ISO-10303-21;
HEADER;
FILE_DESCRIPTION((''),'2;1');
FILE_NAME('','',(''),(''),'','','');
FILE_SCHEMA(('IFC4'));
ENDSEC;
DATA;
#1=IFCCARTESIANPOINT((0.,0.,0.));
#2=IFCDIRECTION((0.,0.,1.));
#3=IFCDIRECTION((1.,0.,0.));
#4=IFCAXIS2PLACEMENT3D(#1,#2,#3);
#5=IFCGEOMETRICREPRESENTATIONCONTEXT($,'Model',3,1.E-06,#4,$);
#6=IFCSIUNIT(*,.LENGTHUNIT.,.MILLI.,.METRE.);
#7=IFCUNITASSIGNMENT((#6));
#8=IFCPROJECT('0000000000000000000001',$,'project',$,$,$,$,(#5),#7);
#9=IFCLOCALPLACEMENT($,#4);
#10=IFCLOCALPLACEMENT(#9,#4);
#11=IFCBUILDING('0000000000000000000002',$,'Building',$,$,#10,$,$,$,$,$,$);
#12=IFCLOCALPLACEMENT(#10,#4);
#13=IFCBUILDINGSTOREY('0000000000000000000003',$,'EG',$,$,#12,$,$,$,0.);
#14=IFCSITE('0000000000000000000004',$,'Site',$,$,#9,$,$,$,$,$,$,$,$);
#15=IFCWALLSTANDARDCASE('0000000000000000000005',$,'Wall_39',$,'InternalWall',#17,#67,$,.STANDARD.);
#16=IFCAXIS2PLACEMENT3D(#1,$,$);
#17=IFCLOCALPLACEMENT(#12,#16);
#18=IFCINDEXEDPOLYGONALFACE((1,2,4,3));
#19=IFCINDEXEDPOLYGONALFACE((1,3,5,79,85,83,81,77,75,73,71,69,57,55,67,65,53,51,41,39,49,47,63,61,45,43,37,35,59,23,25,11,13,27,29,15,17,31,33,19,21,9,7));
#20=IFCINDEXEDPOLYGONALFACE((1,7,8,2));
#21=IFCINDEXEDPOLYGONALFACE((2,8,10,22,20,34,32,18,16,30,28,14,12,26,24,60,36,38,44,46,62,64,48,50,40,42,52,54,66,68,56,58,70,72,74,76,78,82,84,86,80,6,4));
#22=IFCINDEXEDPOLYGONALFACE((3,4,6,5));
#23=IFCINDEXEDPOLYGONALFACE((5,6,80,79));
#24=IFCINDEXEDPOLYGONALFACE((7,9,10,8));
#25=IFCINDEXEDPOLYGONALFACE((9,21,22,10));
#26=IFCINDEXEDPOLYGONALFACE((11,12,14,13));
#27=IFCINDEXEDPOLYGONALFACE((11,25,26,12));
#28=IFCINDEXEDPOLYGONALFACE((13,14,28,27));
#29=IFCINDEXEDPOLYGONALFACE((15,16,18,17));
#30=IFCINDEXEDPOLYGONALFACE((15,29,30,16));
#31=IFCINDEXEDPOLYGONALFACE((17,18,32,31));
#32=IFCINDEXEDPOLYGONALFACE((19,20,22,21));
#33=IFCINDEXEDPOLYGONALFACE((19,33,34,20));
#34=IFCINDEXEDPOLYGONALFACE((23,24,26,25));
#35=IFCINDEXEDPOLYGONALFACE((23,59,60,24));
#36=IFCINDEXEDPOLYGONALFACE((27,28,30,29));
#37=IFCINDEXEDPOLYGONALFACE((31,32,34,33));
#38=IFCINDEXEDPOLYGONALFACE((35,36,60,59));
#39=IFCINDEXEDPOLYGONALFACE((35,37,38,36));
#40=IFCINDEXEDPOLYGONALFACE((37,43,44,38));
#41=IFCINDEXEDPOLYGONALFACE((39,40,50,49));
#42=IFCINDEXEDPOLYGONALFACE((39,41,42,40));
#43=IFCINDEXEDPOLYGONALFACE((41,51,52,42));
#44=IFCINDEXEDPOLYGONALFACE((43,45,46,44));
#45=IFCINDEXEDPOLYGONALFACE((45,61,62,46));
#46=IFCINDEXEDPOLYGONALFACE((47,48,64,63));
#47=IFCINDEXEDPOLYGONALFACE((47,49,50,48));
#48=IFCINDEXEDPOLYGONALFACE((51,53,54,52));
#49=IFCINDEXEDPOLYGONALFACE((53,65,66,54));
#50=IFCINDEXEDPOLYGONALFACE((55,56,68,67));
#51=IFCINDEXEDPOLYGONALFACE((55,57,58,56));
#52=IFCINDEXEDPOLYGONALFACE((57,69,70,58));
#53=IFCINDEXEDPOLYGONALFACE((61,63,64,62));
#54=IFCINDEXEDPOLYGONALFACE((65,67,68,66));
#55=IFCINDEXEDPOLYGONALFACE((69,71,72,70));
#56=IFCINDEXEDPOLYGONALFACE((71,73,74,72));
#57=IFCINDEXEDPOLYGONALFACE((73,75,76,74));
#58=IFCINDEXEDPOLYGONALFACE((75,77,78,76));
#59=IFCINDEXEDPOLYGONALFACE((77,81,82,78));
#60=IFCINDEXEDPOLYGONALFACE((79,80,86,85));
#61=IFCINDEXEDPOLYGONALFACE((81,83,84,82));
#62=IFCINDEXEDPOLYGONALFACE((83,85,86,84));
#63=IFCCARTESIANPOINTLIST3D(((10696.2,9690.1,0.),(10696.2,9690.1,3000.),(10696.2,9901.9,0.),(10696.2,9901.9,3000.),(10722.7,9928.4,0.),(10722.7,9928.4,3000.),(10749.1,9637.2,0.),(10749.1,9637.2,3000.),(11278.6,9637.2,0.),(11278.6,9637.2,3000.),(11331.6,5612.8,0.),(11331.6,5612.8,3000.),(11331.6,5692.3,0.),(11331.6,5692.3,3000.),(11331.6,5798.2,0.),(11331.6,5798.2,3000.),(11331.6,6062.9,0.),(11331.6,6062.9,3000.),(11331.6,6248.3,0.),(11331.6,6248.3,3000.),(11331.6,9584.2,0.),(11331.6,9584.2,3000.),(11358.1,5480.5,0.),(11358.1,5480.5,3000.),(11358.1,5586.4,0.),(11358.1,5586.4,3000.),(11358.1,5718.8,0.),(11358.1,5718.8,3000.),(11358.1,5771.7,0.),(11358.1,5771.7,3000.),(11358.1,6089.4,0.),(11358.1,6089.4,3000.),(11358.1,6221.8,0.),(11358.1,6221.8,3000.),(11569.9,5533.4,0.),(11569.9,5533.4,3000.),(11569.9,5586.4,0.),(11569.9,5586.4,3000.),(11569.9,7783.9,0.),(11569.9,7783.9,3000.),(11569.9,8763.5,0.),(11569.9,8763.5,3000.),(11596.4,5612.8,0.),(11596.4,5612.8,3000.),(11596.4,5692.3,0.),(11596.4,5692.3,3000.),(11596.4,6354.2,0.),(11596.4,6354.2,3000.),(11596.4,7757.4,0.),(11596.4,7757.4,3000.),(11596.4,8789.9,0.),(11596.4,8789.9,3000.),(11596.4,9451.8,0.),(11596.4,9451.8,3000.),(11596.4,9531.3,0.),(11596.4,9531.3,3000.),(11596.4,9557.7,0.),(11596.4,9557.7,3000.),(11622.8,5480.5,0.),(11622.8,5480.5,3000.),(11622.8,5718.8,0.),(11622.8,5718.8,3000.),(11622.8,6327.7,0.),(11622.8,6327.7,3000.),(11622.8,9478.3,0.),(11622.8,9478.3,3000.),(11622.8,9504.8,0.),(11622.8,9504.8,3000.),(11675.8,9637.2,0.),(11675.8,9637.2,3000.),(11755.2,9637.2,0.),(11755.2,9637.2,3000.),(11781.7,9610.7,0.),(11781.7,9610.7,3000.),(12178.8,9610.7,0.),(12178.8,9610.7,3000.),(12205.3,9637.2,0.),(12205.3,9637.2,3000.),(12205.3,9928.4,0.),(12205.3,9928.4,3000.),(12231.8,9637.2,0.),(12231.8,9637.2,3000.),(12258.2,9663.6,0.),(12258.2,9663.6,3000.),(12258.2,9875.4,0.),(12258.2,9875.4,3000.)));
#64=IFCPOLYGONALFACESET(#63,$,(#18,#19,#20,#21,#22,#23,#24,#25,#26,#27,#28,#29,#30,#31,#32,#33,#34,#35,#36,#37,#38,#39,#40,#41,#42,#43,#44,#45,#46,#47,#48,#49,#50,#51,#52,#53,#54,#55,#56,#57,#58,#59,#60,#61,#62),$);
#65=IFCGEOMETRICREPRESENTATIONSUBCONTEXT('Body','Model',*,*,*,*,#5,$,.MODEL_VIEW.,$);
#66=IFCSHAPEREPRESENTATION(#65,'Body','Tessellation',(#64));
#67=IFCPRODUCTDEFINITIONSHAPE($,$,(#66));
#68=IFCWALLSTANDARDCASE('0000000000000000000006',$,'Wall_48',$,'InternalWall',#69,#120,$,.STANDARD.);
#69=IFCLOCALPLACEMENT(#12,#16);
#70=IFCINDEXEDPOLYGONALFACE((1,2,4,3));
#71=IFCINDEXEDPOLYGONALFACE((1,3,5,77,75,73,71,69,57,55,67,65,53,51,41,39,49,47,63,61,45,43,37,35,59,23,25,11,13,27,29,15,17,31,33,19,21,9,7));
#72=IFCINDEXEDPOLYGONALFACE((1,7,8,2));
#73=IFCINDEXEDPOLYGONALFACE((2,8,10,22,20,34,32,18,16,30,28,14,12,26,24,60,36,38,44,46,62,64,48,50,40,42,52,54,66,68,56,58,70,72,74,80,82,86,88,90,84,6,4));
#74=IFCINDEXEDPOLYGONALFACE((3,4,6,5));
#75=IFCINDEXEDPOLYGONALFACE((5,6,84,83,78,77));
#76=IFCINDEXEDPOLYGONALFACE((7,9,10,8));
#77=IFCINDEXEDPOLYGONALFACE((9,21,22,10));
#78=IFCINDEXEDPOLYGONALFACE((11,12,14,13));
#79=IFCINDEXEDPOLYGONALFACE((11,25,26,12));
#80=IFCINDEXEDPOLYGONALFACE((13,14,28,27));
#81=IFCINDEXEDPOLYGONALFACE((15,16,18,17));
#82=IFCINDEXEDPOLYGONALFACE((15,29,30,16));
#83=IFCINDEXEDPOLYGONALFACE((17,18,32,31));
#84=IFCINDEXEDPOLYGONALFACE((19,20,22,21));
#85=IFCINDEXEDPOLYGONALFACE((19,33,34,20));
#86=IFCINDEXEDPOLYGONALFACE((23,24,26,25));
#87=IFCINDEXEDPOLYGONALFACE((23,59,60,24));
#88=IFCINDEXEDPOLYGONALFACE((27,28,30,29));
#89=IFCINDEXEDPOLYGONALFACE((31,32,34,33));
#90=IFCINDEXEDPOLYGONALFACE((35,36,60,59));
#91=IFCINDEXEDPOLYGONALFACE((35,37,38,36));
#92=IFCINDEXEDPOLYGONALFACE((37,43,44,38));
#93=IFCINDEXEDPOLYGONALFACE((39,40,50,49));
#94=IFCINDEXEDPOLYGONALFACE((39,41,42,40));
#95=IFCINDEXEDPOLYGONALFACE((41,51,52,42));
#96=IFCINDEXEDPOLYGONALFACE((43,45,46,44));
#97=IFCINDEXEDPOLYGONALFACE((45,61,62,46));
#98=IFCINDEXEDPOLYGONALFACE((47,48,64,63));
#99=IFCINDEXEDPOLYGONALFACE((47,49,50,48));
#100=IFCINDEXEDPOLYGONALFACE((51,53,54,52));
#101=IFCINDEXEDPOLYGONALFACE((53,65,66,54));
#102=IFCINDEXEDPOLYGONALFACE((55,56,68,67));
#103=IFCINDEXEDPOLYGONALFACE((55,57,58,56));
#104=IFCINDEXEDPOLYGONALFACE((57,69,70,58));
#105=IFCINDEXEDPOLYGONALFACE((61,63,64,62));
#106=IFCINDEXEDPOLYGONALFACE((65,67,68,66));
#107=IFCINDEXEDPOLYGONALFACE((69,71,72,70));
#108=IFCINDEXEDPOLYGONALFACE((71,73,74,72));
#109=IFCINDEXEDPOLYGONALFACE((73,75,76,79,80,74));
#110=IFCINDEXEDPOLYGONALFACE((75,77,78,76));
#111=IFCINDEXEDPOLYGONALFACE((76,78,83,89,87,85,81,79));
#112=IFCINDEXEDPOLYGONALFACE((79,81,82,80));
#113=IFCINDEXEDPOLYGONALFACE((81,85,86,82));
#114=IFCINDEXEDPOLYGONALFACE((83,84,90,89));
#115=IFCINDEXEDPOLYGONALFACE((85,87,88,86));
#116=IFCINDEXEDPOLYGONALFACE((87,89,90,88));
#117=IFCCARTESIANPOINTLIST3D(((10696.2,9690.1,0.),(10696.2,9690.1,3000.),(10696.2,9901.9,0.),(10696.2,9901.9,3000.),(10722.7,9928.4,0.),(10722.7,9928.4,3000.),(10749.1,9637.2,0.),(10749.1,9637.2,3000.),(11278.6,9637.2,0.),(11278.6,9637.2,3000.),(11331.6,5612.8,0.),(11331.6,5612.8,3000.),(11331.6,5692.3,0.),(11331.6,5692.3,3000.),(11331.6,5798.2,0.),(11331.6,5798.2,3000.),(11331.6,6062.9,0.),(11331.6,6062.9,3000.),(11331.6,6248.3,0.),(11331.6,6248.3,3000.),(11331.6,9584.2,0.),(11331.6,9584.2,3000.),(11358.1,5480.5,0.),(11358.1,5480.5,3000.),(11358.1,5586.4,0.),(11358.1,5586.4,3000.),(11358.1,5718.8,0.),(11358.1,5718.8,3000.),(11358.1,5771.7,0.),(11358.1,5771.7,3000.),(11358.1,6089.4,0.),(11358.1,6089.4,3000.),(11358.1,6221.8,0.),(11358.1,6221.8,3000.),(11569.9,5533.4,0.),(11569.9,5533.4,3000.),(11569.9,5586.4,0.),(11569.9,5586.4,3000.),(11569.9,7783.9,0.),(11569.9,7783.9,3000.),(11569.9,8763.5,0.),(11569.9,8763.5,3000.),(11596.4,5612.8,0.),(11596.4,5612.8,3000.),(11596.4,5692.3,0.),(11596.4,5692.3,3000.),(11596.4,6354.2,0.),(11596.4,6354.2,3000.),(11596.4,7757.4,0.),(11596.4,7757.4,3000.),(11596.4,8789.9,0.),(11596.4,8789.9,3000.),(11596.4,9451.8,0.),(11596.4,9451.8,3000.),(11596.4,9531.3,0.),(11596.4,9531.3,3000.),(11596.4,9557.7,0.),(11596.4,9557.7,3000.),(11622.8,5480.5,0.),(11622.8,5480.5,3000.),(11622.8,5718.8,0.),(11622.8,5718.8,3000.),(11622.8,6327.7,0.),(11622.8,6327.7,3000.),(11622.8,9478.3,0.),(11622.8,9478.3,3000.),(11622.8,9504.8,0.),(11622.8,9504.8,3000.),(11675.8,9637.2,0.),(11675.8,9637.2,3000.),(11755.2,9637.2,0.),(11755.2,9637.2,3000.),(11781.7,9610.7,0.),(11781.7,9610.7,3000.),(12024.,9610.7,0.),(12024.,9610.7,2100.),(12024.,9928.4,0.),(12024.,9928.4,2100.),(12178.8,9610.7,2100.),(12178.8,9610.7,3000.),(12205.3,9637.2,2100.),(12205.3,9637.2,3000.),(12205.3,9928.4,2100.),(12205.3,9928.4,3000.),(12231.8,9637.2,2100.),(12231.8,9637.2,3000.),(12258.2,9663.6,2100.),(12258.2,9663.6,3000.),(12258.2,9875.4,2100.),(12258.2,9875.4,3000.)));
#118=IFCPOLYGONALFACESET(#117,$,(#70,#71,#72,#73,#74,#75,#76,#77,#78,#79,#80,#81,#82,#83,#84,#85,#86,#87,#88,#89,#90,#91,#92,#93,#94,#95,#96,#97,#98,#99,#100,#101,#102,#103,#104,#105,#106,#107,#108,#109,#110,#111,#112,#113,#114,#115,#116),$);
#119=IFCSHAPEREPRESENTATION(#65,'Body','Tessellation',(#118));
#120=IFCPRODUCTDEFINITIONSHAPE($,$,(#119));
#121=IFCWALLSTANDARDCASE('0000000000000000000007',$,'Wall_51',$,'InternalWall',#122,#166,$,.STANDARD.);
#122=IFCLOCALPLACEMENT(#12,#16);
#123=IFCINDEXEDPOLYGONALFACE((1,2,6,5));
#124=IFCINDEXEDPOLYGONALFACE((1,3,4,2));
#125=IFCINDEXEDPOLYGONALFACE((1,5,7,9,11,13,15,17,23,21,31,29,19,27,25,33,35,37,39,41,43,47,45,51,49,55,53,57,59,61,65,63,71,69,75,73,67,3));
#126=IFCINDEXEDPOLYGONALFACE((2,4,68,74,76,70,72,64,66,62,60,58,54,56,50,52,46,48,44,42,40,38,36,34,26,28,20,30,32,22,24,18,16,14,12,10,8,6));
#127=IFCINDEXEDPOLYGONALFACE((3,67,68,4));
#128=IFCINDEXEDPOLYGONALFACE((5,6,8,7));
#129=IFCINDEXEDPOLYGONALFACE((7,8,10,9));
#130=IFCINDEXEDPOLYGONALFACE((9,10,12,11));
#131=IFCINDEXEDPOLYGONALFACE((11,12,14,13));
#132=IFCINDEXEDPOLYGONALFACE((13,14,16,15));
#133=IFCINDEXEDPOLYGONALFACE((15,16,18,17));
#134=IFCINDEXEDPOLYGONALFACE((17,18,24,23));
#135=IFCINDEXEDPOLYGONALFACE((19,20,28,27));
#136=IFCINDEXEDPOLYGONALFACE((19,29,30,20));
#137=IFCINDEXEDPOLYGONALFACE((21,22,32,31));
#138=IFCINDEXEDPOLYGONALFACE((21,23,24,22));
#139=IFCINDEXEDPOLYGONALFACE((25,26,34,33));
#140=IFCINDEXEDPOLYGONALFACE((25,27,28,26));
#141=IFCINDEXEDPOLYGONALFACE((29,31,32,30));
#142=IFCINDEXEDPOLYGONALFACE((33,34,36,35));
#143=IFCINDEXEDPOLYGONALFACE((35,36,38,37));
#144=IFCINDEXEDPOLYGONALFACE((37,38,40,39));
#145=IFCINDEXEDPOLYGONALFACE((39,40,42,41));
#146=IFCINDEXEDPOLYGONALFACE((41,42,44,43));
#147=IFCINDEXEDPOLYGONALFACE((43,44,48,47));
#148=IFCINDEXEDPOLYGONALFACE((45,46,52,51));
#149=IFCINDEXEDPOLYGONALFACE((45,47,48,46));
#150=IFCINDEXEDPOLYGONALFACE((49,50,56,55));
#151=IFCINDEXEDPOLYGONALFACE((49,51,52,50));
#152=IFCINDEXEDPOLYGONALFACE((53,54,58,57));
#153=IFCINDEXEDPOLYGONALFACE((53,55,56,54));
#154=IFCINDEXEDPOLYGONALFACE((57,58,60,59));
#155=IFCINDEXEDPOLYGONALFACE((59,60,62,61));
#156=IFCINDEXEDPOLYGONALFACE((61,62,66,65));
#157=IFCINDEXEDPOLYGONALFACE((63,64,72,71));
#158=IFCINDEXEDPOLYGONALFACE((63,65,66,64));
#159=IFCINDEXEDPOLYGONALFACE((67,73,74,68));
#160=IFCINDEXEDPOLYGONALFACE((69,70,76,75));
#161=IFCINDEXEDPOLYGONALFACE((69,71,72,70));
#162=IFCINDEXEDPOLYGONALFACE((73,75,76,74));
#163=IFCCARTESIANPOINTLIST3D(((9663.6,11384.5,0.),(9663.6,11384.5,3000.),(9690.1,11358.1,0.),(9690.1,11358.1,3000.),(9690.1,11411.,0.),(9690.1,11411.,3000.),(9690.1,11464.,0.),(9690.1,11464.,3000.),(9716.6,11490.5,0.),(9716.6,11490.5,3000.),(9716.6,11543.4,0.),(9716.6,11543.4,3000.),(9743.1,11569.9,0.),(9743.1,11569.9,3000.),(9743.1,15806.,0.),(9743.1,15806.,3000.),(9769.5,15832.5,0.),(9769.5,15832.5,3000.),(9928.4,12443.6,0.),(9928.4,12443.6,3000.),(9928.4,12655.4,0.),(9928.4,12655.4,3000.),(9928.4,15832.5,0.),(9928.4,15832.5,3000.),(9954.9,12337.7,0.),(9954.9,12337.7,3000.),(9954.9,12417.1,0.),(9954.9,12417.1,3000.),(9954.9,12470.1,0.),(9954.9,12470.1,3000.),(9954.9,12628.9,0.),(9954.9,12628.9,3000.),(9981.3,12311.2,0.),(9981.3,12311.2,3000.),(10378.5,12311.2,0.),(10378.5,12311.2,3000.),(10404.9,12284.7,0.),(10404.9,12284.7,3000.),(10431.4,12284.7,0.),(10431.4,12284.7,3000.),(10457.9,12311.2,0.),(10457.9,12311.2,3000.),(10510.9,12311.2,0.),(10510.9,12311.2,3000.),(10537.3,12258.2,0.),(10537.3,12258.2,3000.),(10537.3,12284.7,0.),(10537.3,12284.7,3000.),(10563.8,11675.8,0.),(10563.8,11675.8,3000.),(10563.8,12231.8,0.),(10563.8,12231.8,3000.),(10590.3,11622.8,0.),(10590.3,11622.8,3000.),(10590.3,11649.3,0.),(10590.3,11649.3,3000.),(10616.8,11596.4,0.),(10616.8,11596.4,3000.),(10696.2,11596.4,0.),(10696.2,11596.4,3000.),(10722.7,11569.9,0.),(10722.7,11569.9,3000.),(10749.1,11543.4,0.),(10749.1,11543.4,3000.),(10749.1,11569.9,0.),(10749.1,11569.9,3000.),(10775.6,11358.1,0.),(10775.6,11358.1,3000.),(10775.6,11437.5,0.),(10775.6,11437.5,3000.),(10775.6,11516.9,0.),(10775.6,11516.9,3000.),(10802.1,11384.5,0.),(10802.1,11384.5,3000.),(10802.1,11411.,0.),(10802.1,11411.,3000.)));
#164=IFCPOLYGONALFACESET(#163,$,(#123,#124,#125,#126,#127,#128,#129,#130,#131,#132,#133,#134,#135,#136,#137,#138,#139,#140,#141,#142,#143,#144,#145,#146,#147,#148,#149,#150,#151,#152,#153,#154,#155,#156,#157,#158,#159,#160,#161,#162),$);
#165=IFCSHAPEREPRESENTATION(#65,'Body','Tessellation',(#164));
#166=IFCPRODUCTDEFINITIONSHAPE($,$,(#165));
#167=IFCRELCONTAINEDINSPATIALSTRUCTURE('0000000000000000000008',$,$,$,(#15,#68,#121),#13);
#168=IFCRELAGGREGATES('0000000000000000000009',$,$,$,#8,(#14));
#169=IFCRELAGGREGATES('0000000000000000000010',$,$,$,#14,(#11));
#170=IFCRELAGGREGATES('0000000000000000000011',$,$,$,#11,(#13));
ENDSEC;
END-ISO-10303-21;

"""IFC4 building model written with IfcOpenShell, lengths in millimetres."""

from ifc_helpers import new_model, si_unit, frame, origin_with_axes, place, context, subcontext, project, spatial, polyline, rectangle, outline, extrude, element, save


model = new_model("IFC4")

# Units and contexts
model_context = context("Model", 3, precision=1e-06, world=origin_with_axes())
body_context = subcontext(model_context, "Body", "Model", "MODEL_VIEW")
ifc_project = project(units=[si_unit("LENGTHUNIT", "METRE", prefix="MILLI")], contexts=[model_context])

# Site, building, storey
site_placement = place(None, origin_with_axes())
site = spatial("IfcSite", under=ifc_project, at=site_placement, Name="Site")
building_placement = place(site_placement, origin_with_axes())
building = spatial("IfcBuilding", under=site, at=building_placement, Name="Building")
storey_placement = place(building_placement, origin_with_axes())
storey = spatial("IfcBuildingStorey", under=building, at=storey_placement, Name="EG", Elevation=0.0)

# Wall
wall_1_placement = place(storey_placement, origin_with_axes())
element("IfcWallStandardCase", 1, at=wall_1_placement, inside=storey, Name="Wall_39", ObjectType="InternalWall", PredefinedType="STANDARD", context=body_context, shape_type="SweptSolid", body=[
    extrude(outline(polyline([(11358.1, 5480.5, 0.0), (11358.1, 5586.4, 0.0), (11331.6, 5612.8, 0.0), (11331.6, 5692.3, 0.0), (11358.1, 5718.8, 0.0), (11358.1, 5771.7, 0.0), (11331.6, 5798.2, 0.0), (11331.6, 6062.9, 0.0), (11358.1, 6089.4, 0.0), (11358.1, 6221.8, 0.0), (11331.6, 6248.3, 0.0), (11331.6, 9584.2, 0.0), (11278.6, 9637.2, 0.0), (10749.1, 9637.2, 0.0), (10696.2, 9690.1, 0.0), (10696.2, 9901.9, 0.0), (10722.7, 9928.4, 0.0), (12205.3, 9928.4, 0.0), (12258.2, 9875.4, 0.0), (12258.2, 9663.6, 0.0), (12231.8, 9637.2, 0.0), (12205.3, 9637.2, 0.0), (12178.8, 9610.7, 0.0), (11781.7, 9610.7, 0.0), (11755.2, 9637.2, 0.0), (11675.8, 9637.2, 0.0), (11596.4, 9557.7, 0.0), (11596.4, 9531.3, 0.0), (11622.8, 9504.8, 0.0), (11622.8, 9478.3, 0.0), (11596.4, 9451.8, 0.0), (11596.4, 8789.9, 0.0), (11569.9, 8763.5, 0.0), (11569.9, 7783.9, 0.0), (11596.4, 7757.4, 0.0), (11596.4, 6354.2, 0.0), (11622.8, 6327.7, 0.0), (11622.8, 5718.8, 0.0), (11596.4, 5692.3, 0.0), (11596.4, 5612.8, 0.0), (11569.9, 5586.4, 0.0), (11569.9, 5533.4, 0.0), (11622.8, 5480.5, 0.0), (11358.1, 5480.5, 0.0)])), origin_with_axes(), (0.0, 0.0, 1.0), 3000.0),
])

# Wall, opening
wall_2_placement = place(storey_placement, origin_with_axes())
wall_2 = element("IfcWallStandardCase", 2, at=wall_2_placement, inside=storey, Name="Wall_48", ObjectType="InternalWall", PredefinedType="STANDARD", context=body_context, shape_type="SweptSolid", body=[
    extrude(outline(polyline([(11358.1, 5480.5, 0.0), (11358.1, 5586.4, 0.0), (11331.6, 5612.8, 0.0), (11331.6, 5692.3, 0.0), (11358.1, 5718.8, 0.0), (11358.1, 5771.7, 0.0), (11331.6, 5798.2, 0.0), (11331.6, 6062.9, 0.0), (11358.1, 6089.4, 0.0), (11358.1, 6221.8, 0.0), (11331.6, 6248.3, 0.0), (11331.6, 9584.2, 0.0), (11278.6, 9637.2, 0.0), (10749.1, 9637.2, 0.0), (10696.2, 9690.1, 0.0), (10696.2, 9901.9, 0.0), (10722.7, 9928.4, 0.0), (12205.3, 9928.4, 0.0), (12258.2, 9875.4, 0.0), (12258.2, 9663.6, 0.0), (12231.8, 9637.2, 0.0), (12205.3, 9637.2, 0.0), (12178.8, 9610.7, 0.0), (11781.7, 9610.7, 0.0), (11755.2, 9637.2, 0.0), (11675.8, 9637.2, 0.0), (11596.4, 9557.7, 0.0), (11596.4, 9531.3, 0.0), (11622.8, 9504.8, 0.0), (11622.8, 9478.3, 0.0), (11596.4, 9451.8, 0.0), (11596.4, 8789.9, 0.0), (11569.9, 8763.5, 0.0), (11569.9, 7783.9, 0.0), (11596.4, 7757.4, 0.0), (11596.4, 6354.2, 0.0), (11622.8, 6327.7, 0.0), (11622.8, 5718.8, 0.0), (11596.4, 5692.3, 0.0), (11596.4, 5612.8, 0.0), (11569.9, 5586.4, 0.0), (11569.9, 5533.4, 0.0), (11622.8, 5480.5, 0.0), (11358.1, 5480.5, 0.0)])), origin_with_axes(), (0.0, 0.0, 1.0), 3000.0),
])
opening_1_placement = place(wall_2_placement, origin_with_axes())
element("IfcOpeningElement", 3, at=opening_1_placement, inside=storey, cuts=wall_2, context=body_context, shape_type="SweptSolid", body=[
    extrude(rectangle(XDim=1319.5, YDim=300.0), frame((12174.0, 9680.5, 0.0), z_axis=(0.0, 0.0, 1.0), x_axis=(0.0, 1.0, 0.0)), (0.0, 0.0, 1.0), 2100.0),
])

# Wall
for number, where, z_axis, x_axis, name in (
    (4, (0.0, 0.0, 0.0), (0.0, 0.0, 1.0), (1.0, 0.0, 0.0), "Wall_51"),
):
    element("IfcWallStandardCase", number, at=place(storey_placement, frame(where, z_axis=z_axis, x_axis=x_axis)), inside=storey, Name=name, ObjectType="InternalWall", PredefinedType="STANDARD", context=body_context, shape_type="SweptSolid", body=[
        extrude(outline(polyline([(9690.1, 11358.1, 0.0), (9663.6, 11384.5, 0.0), (9690.1, 11411.0, 0.0), (9690.1, 11464.0, 0.0), (9716.6, 11490.5, 0.0), (9716.6, 11543.4, 0.0), (9743.1, 11569.9, 0.0), (9743.1, 15806.0, 0.0), (9769.5, 15832.5, 0.0), (9928.4, 15832.5, 0.0), (9928.4, 12655.4, 0.0), (9954.9, 12628.9, 0.0), (9954.9, 12470.1, 0.0), (9928.4, 12443.6, 0.0), (9954.9, 12417.1, 0.0), (9954.9, 12337.7, 0.0), (9981.3, 12311.2, 0.0), (10378.5, 12311.2, 0.0), (10404.9, 12284.7, 0.0), (10431.4, 12284.7, 0.0), (10457.9, 12311.2, 0.0), (10510.9, 12311.2, 0.0), (10537.3, 12284.7, 0.0), (10537.3, 12258.2, 0.0), (10563.8, 12231.8, 0.0), (10563.8, 11675.8, 0.0), (10590.3, 11649.3, 0.0), (10590.3, 11622.8, 0.0), (10616.8, 11596.4, 0.0), (10696.2, 11596.4, 0.0), (10722.7, 11569.9, 0.0), (10749.1, 11569.9, 0.0), (10749.1, 11543.4, 0.0), (10775.6, 11516.9, 0.0), (10775.6, 11437.5, 0.0), (10802.1, 11411.0, 0.0), (10802.1, 11384.5, 0.0), (10775.6, 11358.1, 0.0), (9690.1, 11358.1, 0.0)])), origin_with_axes(), (0.0, 0.0, 1.0), 3000.0),
    ])

save(model, "model.ifc")
